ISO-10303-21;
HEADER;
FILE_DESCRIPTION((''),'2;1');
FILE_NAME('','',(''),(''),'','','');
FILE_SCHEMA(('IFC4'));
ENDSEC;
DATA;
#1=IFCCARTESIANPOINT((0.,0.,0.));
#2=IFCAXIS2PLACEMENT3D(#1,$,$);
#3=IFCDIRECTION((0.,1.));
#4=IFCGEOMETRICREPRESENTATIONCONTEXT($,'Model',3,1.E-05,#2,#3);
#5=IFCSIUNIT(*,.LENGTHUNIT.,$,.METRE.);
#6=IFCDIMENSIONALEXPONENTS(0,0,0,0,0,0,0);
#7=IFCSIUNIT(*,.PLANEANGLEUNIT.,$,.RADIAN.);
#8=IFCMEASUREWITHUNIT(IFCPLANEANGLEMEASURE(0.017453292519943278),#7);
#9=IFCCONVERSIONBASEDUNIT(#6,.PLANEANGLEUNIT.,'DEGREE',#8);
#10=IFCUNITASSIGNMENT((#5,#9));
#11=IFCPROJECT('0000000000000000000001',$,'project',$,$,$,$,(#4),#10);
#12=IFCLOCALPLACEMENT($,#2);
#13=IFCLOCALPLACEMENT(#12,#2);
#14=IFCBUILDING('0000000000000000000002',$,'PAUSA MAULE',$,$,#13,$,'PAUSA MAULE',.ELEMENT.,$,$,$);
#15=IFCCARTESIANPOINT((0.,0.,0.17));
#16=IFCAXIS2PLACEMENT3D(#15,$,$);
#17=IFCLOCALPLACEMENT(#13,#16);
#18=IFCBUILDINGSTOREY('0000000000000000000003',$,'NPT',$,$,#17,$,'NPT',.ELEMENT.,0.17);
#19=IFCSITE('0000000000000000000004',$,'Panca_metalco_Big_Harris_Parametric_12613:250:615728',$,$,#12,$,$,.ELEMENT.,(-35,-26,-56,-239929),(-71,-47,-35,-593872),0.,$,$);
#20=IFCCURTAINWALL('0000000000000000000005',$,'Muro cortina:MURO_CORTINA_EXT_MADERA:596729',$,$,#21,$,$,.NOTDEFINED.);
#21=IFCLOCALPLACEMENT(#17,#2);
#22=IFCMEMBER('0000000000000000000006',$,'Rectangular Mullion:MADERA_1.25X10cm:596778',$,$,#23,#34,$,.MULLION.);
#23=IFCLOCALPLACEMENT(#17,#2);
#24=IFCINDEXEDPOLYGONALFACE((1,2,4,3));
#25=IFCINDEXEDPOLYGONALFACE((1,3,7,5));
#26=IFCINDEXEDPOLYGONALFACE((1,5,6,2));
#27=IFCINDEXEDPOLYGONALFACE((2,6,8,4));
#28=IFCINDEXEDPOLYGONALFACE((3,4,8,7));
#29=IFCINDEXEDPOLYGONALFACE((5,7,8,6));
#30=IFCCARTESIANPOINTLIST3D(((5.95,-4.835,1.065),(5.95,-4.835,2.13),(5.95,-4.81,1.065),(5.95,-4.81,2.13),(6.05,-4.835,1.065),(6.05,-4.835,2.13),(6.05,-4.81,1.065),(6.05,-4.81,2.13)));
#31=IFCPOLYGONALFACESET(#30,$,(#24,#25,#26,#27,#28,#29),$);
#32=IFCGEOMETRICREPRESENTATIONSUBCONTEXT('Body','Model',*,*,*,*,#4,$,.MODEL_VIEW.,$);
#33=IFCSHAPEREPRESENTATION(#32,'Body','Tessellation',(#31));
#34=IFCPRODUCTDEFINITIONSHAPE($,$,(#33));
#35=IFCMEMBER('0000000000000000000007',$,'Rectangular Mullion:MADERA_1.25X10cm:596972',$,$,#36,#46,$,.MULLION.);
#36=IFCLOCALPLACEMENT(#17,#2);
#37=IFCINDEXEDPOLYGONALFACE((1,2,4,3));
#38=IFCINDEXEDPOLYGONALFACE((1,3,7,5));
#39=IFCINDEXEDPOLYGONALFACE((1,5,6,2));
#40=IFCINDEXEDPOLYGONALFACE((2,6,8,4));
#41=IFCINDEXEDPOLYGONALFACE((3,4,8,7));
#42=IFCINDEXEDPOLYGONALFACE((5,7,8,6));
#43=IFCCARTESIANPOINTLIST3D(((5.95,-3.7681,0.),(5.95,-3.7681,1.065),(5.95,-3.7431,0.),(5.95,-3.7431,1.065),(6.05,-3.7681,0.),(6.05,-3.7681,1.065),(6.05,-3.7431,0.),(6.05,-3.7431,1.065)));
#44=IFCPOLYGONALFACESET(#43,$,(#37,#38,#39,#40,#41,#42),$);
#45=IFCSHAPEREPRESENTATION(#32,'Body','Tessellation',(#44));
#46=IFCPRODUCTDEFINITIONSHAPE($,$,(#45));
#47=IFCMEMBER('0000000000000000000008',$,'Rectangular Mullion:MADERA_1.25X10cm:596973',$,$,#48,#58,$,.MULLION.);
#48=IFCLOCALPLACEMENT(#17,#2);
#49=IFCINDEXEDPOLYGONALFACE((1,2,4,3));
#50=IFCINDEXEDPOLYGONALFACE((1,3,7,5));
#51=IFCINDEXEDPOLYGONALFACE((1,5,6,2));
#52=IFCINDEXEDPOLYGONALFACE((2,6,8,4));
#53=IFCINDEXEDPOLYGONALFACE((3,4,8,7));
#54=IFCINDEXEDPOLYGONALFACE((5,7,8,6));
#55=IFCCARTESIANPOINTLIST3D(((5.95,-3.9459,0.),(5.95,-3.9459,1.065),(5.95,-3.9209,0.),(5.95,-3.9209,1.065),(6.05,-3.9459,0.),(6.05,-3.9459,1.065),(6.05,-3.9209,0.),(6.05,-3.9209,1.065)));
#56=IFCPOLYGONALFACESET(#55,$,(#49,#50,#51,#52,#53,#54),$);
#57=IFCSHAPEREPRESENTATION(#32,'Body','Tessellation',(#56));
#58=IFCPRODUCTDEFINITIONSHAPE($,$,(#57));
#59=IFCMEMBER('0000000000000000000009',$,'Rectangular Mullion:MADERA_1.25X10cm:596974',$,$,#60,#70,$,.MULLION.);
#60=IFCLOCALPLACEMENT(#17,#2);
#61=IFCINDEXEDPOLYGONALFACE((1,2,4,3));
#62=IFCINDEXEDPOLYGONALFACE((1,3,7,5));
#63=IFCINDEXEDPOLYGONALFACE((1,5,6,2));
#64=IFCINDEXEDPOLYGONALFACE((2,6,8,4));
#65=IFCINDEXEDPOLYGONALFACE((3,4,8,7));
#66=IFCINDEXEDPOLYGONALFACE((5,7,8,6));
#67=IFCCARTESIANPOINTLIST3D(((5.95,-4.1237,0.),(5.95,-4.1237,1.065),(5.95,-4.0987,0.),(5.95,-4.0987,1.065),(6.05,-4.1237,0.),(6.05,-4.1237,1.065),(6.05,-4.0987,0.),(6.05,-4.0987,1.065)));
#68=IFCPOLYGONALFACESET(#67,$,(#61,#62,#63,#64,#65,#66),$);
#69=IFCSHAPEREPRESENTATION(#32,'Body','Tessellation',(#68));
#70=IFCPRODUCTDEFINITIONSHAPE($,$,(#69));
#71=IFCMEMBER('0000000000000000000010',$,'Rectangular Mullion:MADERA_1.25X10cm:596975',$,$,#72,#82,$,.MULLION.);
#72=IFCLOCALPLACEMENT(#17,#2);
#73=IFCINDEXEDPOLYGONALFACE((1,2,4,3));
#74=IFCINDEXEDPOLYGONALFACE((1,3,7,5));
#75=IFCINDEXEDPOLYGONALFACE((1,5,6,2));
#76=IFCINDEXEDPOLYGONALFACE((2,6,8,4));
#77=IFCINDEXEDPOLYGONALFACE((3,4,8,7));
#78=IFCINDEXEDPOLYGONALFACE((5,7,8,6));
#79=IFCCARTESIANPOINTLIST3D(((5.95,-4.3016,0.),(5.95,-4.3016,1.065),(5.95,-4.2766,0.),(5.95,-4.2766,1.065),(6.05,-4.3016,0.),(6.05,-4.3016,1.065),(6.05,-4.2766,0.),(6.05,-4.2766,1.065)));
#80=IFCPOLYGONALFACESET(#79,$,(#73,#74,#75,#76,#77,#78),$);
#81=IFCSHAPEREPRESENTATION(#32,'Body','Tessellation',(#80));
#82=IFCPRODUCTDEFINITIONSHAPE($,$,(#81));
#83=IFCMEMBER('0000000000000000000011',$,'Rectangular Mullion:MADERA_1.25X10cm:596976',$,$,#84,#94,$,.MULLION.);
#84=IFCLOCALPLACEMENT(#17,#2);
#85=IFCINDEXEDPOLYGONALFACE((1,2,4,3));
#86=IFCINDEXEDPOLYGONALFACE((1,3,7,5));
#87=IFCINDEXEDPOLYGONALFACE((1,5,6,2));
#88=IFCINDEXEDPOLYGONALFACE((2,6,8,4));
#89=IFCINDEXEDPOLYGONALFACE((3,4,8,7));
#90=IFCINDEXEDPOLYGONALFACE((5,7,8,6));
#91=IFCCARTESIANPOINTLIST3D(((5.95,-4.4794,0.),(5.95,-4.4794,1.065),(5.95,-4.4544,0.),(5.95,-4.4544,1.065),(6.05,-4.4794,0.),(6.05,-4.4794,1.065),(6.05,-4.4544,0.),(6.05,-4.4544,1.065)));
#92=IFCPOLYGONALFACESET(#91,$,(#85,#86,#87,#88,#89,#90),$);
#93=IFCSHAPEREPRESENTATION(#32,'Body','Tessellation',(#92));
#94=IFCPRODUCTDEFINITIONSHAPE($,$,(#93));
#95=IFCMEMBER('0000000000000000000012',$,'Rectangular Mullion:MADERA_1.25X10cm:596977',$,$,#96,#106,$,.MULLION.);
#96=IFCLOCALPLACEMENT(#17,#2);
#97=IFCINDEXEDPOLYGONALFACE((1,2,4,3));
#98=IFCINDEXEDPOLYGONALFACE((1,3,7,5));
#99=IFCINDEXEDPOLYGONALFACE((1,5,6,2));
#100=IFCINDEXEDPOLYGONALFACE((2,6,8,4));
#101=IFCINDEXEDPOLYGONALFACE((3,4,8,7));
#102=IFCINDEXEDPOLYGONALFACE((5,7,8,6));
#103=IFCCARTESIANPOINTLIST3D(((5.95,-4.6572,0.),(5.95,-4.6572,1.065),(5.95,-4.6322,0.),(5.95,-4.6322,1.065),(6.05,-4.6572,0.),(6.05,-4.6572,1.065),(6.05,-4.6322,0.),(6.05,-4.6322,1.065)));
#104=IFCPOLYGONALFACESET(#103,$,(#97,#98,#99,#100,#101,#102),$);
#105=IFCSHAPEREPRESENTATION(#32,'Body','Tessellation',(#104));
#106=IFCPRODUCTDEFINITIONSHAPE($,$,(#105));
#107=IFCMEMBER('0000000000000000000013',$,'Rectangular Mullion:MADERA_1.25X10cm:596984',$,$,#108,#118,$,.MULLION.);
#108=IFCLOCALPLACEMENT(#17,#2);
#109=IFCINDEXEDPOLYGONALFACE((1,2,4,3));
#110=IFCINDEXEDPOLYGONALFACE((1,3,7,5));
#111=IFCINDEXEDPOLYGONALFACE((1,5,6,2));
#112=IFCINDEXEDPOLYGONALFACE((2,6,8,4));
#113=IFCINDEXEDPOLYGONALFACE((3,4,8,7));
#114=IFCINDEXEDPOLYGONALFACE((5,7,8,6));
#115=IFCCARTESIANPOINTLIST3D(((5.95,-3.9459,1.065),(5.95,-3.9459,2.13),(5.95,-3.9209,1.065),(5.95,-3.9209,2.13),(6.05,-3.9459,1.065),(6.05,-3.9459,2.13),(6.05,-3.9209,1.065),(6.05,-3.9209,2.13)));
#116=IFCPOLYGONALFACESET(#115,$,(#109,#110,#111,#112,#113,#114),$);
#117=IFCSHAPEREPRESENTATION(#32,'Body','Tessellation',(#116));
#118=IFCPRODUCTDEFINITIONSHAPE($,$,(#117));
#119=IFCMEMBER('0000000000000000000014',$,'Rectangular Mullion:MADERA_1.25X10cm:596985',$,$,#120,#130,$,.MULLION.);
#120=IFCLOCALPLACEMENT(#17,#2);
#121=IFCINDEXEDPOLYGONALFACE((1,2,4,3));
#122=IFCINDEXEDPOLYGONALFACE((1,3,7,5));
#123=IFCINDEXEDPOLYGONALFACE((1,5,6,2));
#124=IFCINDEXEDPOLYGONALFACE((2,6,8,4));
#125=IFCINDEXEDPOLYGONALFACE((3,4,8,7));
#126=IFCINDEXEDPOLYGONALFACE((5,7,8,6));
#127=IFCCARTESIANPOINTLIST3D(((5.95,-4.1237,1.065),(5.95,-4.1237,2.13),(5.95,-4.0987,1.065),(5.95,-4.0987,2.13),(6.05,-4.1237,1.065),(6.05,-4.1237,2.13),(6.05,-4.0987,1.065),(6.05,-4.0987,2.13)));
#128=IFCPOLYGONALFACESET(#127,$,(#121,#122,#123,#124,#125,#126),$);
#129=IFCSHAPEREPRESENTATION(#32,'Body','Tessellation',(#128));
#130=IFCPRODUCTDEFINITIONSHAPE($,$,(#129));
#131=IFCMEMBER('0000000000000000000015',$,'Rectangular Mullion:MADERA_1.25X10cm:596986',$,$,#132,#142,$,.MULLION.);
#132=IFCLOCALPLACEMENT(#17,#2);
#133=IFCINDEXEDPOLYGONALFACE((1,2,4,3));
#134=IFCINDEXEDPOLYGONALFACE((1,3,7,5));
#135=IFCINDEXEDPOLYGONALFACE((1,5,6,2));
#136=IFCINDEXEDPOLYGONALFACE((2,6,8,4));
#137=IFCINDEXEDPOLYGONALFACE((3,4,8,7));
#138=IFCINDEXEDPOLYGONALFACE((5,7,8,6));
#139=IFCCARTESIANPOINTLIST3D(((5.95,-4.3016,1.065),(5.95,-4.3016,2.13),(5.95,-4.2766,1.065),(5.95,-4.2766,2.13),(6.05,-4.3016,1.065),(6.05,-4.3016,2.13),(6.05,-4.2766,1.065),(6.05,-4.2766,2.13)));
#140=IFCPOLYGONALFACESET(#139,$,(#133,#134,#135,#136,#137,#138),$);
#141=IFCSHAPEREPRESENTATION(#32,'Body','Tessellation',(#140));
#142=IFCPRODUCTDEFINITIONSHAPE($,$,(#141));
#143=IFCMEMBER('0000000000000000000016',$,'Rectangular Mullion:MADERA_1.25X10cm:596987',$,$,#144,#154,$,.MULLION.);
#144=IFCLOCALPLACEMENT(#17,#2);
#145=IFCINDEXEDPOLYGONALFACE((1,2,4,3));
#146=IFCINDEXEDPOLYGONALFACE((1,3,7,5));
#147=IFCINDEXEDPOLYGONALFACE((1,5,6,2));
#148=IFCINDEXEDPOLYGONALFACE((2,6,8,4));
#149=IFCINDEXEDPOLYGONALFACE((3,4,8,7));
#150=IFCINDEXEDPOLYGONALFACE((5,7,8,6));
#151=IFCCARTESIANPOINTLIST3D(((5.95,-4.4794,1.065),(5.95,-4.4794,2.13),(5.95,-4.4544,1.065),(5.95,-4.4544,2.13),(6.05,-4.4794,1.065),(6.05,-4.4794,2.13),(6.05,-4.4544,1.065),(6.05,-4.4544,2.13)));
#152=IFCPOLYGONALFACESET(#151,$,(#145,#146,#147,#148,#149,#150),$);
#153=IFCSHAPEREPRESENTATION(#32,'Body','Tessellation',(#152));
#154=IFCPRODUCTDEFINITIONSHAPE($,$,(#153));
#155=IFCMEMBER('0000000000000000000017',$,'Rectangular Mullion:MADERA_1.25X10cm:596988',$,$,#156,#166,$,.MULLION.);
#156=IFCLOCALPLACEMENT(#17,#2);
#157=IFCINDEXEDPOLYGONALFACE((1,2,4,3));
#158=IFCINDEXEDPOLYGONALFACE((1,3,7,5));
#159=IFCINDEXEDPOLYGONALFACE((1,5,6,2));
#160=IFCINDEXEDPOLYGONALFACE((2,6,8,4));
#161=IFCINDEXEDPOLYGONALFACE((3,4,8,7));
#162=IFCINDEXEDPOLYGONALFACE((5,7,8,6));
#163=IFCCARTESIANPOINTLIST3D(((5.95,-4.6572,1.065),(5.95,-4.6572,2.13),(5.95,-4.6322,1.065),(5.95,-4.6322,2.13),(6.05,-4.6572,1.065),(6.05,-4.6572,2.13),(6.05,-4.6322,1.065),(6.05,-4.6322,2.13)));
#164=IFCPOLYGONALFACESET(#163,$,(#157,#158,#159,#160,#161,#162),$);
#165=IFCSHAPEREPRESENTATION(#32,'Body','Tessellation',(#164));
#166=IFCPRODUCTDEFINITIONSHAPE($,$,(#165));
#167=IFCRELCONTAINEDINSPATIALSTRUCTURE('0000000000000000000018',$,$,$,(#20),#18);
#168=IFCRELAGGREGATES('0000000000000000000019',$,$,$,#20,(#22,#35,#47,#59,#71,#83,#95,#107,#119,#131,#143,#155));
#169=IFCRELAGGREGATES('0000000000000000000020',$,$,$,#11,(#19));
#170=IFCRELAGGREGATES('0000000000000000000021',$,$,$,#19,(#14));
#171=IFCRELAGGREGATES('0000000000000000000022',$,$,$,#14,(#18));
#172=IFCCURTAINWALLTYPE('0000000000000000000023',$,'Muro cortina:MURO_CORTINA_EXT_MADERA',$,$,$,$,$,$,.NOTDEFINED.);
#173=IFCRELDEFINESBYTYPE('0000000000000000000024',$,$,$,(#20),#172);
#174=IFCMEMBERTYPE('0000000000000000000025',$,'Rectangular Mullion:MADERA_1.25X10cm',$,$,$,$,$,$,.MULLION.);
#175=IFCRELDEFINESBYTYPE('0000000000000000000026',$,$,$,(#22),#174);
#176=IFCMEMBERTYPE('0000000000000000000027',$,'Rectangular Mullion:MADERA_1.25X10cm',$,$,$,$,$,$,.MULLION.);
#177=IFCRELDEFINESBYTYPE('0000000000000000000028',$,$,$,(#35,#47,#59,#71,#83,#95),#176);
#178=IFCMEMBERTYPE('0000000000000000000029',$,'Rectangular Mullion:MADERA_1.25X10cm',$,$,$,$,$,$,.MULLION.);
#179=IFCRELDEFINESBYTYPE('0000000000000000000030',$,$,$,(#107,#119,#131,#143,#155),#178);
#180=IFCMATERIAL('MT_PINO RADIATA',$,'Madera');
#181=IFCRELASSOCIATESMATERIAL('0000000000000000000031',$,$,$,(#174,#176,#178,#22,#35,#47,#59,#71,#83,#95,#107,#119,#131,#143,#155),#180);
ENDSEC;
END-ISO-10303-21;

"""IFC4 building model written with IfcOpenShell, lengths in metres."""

from ifc_helpers import new_model, entity, si_unit, converted_unit, direction, frame, frame_2d, origin, origin_2d_with_axis, place, context, subcontext, project, spatial, rectangle, extrude, source, transform, mapped, material, material_profile, profile_set, profile_usage, type_object, type_shapes, element, aggregate, save


model = new_model("IFC4")

# Units and contexts
model_context = context("Model", 3, precision=1e-05, world=origin(), true_north=direction((0.0, 1.0)))
body_context = subcontext(model_context, "Body", "Model", "MODEL_VIEW")
ifc_project = project(units=[si_unit("LENGTHUNIT", "METRE"), converted_unit("PLANEANGLEUNIT", "DEGREE", entity("IfcPlaneAngleMeasure", 0.017453292519943278), si_unit("PLANEANGLEUNIT", "RADIAN"), dimensions=[0, 0, 0, 0, 0, 0, 0])], contexts=[model_context])

# Site, building, storey
site_placement = place(None, origin())
site = spatial("IfcSite", under=ifc_project, at=site_placement, Name="Panca_metalco_Big_Harris_Parametric_12613:250:615728", CompositionType="ELEMENT", RefLatitude=(-35, -26, -56, -239929), RefLongitude=(-71, -47, -35, -593872), RefElevation=0.0)
building_placement = place(site_placement, origin())
building = spatial("IfcBuilding", under=site, at=building_placement, Name="PAUSA MAULE", LongName="PAUSA MAULE", CompositionType="ELEMENT")
storey_placement = place(building_placement, frame((0.0, 0.0, 0.17)))
storey = spatial("IfcBuildingStorey", under=building, at=storey_placement, Name="NPT", LongName="NPT", CompositionType="ELEMENT", Elevation=0.17)

# Curtain wall, members
curtain_wall_type = type_object("IfcCurtainWallType", Name="Muro cortina:MURO_CORTINA_EXT_MADERA", PredefinedType="NOTDEFINED")
curtain_wall_placement = place(storey_placement, frame((0.0, 0.0, -0.17)))
curtain_wall = element("IfcCurtainWall", 1, at=curtain_wall_placement, inside=storey, type_object=curtain_wall_type, Name="Muro cortina:MURO_CORTINA_EXT_MADERA:596729", PredefinedType="NOTDEFINED")
ifc_material = material(Name="MT_PINO RADIATA", Category="Madera")
ifc_material_profile = material_profile(ifc_material, rectangle(XDim=0.025, YDim=0.1, at=frame_2d((0.0, 0.0), x_axis=(1.0, 0.0))), Name="MADERA_1.25X10cm")
ifc_profile_set = profile_set([ifc_material_profile], Name="MADERA_1.25X10cm")
ifc_profile_usage = profile_usage(ifc_profile_set)
member_type_1 = type_object("IfcMemberType", Name="Rectangular Mullion:MADERA_1.25X10cm", PredefinedType="MULLION", material=ifc_profile_set)
shared_shape_1 = source(origin(), body_context, "Body", "SweptSolid", [
    extrude(rectangle(XDim=0.025, YDim=0.1, at=origin_2d_with_axis()), frame((-0.0125, 0.0, -1.065), z_axis=(0.0, 0.0, 1.0), x_axis=(-1.0, 0.0, 0.0)), (0.0, 0.0, 1.0), 1.065),
])
type_shapes(member_type_1, [shared_shape_1])
member_1_placement = place(curtain_wall_placement, frame((6.0, -4.835, 1.235), z_axis=(0.0, 0.0, -1.0), x_axis=(0.0, -1.0, 0.0)))
member_1 = element("IfcMember", 2, at=member_1_placement, type_object=member_type_1, material=ifc_profile_usage, Name="Rectangular Mullion:MADERA_1.25X10cm:596778", PredefinedType="MULLION", context=body_context, shape_type="MappedRepresentation", body=[
    mapped(shared_shape_1, transform((0.0, 0.0, 0.0), scale=1.0)),
])
member_type_2 = type_object("IfcMemberType", Name="Rectangular Mullion:MADERA_1.25X10cm", PredefinedType="MULLION", material=ifc_profile_set)
shared_shape_2 = source(origin(), body_context, "Body", "SweptSolid", [
    extrude(rectangle(XDim=0.025, YDim=0.1, at=frame_2d((0.0, 0.0), x_axis=(1.0, 0.0))), frame((0.0, 0.0, -1.065), z_axis=(0.0, 0.0, 1.0), x_axis=(-1.0, 0.0, 0.0)), (0.0, 0.0, 1.0), 1.065),
])
type_shapes(member_type_2, [shared_shape_2])
member_2_placement = place(curtain_wall_placement, frame((6.0, -3.7556, 0.17), z_axis=(0.0, 0.0, -1.0), x_axis=(0.0, -1.0, 0.0)))
member_2 = element("IfcMember", 3, at=member_2_placement, type_object=member_type_2, material=ifc_profile_usage, Name="Rectangular Mullion:MADERA_1.25X10cm:596972", PredefinedType="MULLION", context=body_context, shape_type="MappedRepresentation", body=[
    mapped(shared_shape_2, transform((0.0, 0.0, 0.0), scale=1.0)),
])
member_3_placement = place(curtain_wall_placement, frame((6.0, -3.9334, 0.17), z_axis=(0.0, 0.0, -1.0), x_axis=(0.0, -1.0, 0.0)))
member_3 = element("IfcMember", 4, at=member_3_placement, type_object=member_type_2, material=ifc_profile_usage, Name="Rectangular Mullion:MADERA_1.25X10cm:596973", PredefinedType="MULLION", context=body_context, shape_type="MappedRepresentation", body=[
    mapped(shared_shape_2, transform((0.0, 0.0, 0.0), scale=1.0)),
])
member_4_placement = place(curtain_wall_placement, frame((6.0, -4.1112, 0.17), z_axis=(0.0, 0.0, -1.0), x_axis=(0.0, -1.0, 0.0)))
member_4 = element("IfcMember", 5, at=member_4_placement, type_object=member_type_2, material=ifc_profile_usage, Name="Rectangular Mullion:MADERA_1.25X10cm:596974", PredefinedType="MULLION", context=body_context, shape_type="MappedRepresentation", body=[
    mapped(shared_shape_2, transform((0.0, 0.0, 0.0), scale=1.0)),
])
member_5_placement = place(curtain_wall_placement, frame((6.0, -4.2891, 0.17), z_axis=(0.0, 0.0, -1.0), x_axis=(0.0, -1.0, 0.0)))
member_5 = element("IfcMember", 6, at=member_5_placement, type_object=member_type_2, material=ifc_profile_usage, Name="Rectangular Mullion:MADERA_1.25X10cm:596975", PredefinedType="MULLION", context=body_context, shape_type="MappedRepresentation", body=[
    mapped(shared_shape_2, transform((0.0, 0.0, 0.0), scale=1.0)),
])
member_6_placement = place(curtain_wall_placement, frame((6.0, -4.4669, 0.17), z_axis=(0.0, 0.0, -1.0), x_axis=(0.0, -1.0, 0.0)))
member_6 = element("IfcMember", 7, at=member_6_placement, type_object=member_type_2, material=ifc_profile_usage, Name="Rectangular Mullion:MADERA_1.25X10cm:596976", PredefinedType="MULLION", context=body_context, shape_type="MappedRepresentation", body=[
    mapped(shared_shape_2, transform((0.0, 0.0, 0.0), scale=1.0)),
])
member_7_placement = place(curtain_wall_placement, frame((6.0, -4.6447, 0.17), z_axis=(0.0, 0.0, -1.0), x_axis=(0.0, -1.0, 0.0)))
member_7 = element("IfcMember", 8, at=member_7_placement, type_object=member_type_2, material=ifc_profile_usage, Name="Rectangular Mullion:MADERA_1.25X10cm:596977", PredefinedType="MULLION", context=body_context, shape_type="MappedRepresentation", body=[
    mapped(shared_shape_2, transform((0.0, 0.0, 0.0), scale=1.0)),
])
member_type_3 = type_object("IfcMemberType", Name="Rectangular Mullion:MADERA_1.25X10cm", PredefinedType="MULLION", material=ifc_profile_set)
shared_shape_3 = source(origin(), body_context, "Body", "SweptSolid", [
    extrude(rectangle(XDim=0.025, YDim=0.1, at=frame_2d((0.0, 0.0), x_axis=(1.0, 0.0))), frame((0.0, 0.0, -1.065), z_axis=(0.0, 0.0, 1.0), x_axis=(-1.0, 0.0, 0.0)), (0.0, 0.0, 1.0), 1.065),
])
type_shapes(member_type_3, [shared_shape_3])
member_8_placement = place(curtain_wall_placement, frame((6.0, -3.9334, 1.235), z_axis=(0.0, 0.0, -1.0), x_axis=(0.0, -1.0, 0.0)))
member_8 = element("IfcMember", 9, at=member_8_placement, type_object=member_type_3, material=ifc_profile_usage, Name="Rectangular Mullion:MADERA_1.25X10cm:596984", PredefinedType="MULLION", context=body_context, shape_type="MappedRepresentation", body=[
    mapped(shared_shape_3, transform((0.0, 0.0, 0.0), scale=1.0)),
])
member_9_placement = place(curtain_wall_placement, frame((6.0, -4.1112, 1.235), z_axis=(0.0, 0.0, -1.0), x_axis=(0.0, -1.0, 0.0)))
member_9 = element("IfcMember", 10, at=member_9_placement, type_object=member_type_3, material=ifc_profile_usage, Name="Rectangular Mullion:MADERA_1.25X10cm:596985", PredefinedType="MULLION", context=body_context, shape_type="MappedRepresentation", body=[
    mapped(shared_shape_3, transform((0.0, 0.0, 0.0), scale=1.0)),
])
member_10_placement = place(curtain_wall_placement, frame((6.0, -4.2891, 1.235), z_axis=(0.0, 0.0, -1.0), x_axis=(0.0, -1.0, 0.0)))
member_10 = element("IfcMember", 11, at=member_10_placement, type_object=member_type_3, material=ifc_profile_usage, Name="Rectangular Mullion:MADERA_1.25X10cm:596986", PredefinedType="MULLION", context=body_context, shape_type="MappedRepresentation", body=[
    mapped(shared_shape_3, transform((0.0, 0.0, 0.0), scale=1.0)),
])
member_11_placement = place(curtain_wall_placement, frame((6.0, -4.4669, 1.235), z_axis=(0.0, 0.0, -1.0), x_axis=(0.0, -1.0, 0.0)))
member_11 = element("IfcMember", 12, at=member_11_placement, type_object=member_type_3, material=ifc_profile_usage, Name="Rectangular Mullion:MADERA_1.25X10cm:596987", PredefinedType="MULLION", context=body_context, shape_type="MappedRepresentation", body=[
    mapped(shared_shape_3, transform((0.0, 0.0, 0.0), scale=1.0)),
])
member_12_placement = place(curtain_wall_placement, frame((6.0, -4.6447, 1.235), z_axis=(0.0, 0.0, -1.0), x_axis=(0.0, -1.0, 0.0)))
member_12 = element("IfcMember", 13, at=member_12_placement, type_object=member_type_3, material=ifc_profile_usage, Name="Rectangular Mullion:MADERA_1.25X10cm:596988", PredefinedType="MULLION", context=body_context, shape_type="MappedRepresentation", body=[
    mapped(shared_shape_3, transform((0.0, 0.0, 0.0), scale=1.0)),
])
aggregate(curtain_wall, [member_1, member_2, member_3, member_4, member_5, member_6, member_7, member_8, member_9, member_10, member_11, member_12])

save(model, "model.ifc")
